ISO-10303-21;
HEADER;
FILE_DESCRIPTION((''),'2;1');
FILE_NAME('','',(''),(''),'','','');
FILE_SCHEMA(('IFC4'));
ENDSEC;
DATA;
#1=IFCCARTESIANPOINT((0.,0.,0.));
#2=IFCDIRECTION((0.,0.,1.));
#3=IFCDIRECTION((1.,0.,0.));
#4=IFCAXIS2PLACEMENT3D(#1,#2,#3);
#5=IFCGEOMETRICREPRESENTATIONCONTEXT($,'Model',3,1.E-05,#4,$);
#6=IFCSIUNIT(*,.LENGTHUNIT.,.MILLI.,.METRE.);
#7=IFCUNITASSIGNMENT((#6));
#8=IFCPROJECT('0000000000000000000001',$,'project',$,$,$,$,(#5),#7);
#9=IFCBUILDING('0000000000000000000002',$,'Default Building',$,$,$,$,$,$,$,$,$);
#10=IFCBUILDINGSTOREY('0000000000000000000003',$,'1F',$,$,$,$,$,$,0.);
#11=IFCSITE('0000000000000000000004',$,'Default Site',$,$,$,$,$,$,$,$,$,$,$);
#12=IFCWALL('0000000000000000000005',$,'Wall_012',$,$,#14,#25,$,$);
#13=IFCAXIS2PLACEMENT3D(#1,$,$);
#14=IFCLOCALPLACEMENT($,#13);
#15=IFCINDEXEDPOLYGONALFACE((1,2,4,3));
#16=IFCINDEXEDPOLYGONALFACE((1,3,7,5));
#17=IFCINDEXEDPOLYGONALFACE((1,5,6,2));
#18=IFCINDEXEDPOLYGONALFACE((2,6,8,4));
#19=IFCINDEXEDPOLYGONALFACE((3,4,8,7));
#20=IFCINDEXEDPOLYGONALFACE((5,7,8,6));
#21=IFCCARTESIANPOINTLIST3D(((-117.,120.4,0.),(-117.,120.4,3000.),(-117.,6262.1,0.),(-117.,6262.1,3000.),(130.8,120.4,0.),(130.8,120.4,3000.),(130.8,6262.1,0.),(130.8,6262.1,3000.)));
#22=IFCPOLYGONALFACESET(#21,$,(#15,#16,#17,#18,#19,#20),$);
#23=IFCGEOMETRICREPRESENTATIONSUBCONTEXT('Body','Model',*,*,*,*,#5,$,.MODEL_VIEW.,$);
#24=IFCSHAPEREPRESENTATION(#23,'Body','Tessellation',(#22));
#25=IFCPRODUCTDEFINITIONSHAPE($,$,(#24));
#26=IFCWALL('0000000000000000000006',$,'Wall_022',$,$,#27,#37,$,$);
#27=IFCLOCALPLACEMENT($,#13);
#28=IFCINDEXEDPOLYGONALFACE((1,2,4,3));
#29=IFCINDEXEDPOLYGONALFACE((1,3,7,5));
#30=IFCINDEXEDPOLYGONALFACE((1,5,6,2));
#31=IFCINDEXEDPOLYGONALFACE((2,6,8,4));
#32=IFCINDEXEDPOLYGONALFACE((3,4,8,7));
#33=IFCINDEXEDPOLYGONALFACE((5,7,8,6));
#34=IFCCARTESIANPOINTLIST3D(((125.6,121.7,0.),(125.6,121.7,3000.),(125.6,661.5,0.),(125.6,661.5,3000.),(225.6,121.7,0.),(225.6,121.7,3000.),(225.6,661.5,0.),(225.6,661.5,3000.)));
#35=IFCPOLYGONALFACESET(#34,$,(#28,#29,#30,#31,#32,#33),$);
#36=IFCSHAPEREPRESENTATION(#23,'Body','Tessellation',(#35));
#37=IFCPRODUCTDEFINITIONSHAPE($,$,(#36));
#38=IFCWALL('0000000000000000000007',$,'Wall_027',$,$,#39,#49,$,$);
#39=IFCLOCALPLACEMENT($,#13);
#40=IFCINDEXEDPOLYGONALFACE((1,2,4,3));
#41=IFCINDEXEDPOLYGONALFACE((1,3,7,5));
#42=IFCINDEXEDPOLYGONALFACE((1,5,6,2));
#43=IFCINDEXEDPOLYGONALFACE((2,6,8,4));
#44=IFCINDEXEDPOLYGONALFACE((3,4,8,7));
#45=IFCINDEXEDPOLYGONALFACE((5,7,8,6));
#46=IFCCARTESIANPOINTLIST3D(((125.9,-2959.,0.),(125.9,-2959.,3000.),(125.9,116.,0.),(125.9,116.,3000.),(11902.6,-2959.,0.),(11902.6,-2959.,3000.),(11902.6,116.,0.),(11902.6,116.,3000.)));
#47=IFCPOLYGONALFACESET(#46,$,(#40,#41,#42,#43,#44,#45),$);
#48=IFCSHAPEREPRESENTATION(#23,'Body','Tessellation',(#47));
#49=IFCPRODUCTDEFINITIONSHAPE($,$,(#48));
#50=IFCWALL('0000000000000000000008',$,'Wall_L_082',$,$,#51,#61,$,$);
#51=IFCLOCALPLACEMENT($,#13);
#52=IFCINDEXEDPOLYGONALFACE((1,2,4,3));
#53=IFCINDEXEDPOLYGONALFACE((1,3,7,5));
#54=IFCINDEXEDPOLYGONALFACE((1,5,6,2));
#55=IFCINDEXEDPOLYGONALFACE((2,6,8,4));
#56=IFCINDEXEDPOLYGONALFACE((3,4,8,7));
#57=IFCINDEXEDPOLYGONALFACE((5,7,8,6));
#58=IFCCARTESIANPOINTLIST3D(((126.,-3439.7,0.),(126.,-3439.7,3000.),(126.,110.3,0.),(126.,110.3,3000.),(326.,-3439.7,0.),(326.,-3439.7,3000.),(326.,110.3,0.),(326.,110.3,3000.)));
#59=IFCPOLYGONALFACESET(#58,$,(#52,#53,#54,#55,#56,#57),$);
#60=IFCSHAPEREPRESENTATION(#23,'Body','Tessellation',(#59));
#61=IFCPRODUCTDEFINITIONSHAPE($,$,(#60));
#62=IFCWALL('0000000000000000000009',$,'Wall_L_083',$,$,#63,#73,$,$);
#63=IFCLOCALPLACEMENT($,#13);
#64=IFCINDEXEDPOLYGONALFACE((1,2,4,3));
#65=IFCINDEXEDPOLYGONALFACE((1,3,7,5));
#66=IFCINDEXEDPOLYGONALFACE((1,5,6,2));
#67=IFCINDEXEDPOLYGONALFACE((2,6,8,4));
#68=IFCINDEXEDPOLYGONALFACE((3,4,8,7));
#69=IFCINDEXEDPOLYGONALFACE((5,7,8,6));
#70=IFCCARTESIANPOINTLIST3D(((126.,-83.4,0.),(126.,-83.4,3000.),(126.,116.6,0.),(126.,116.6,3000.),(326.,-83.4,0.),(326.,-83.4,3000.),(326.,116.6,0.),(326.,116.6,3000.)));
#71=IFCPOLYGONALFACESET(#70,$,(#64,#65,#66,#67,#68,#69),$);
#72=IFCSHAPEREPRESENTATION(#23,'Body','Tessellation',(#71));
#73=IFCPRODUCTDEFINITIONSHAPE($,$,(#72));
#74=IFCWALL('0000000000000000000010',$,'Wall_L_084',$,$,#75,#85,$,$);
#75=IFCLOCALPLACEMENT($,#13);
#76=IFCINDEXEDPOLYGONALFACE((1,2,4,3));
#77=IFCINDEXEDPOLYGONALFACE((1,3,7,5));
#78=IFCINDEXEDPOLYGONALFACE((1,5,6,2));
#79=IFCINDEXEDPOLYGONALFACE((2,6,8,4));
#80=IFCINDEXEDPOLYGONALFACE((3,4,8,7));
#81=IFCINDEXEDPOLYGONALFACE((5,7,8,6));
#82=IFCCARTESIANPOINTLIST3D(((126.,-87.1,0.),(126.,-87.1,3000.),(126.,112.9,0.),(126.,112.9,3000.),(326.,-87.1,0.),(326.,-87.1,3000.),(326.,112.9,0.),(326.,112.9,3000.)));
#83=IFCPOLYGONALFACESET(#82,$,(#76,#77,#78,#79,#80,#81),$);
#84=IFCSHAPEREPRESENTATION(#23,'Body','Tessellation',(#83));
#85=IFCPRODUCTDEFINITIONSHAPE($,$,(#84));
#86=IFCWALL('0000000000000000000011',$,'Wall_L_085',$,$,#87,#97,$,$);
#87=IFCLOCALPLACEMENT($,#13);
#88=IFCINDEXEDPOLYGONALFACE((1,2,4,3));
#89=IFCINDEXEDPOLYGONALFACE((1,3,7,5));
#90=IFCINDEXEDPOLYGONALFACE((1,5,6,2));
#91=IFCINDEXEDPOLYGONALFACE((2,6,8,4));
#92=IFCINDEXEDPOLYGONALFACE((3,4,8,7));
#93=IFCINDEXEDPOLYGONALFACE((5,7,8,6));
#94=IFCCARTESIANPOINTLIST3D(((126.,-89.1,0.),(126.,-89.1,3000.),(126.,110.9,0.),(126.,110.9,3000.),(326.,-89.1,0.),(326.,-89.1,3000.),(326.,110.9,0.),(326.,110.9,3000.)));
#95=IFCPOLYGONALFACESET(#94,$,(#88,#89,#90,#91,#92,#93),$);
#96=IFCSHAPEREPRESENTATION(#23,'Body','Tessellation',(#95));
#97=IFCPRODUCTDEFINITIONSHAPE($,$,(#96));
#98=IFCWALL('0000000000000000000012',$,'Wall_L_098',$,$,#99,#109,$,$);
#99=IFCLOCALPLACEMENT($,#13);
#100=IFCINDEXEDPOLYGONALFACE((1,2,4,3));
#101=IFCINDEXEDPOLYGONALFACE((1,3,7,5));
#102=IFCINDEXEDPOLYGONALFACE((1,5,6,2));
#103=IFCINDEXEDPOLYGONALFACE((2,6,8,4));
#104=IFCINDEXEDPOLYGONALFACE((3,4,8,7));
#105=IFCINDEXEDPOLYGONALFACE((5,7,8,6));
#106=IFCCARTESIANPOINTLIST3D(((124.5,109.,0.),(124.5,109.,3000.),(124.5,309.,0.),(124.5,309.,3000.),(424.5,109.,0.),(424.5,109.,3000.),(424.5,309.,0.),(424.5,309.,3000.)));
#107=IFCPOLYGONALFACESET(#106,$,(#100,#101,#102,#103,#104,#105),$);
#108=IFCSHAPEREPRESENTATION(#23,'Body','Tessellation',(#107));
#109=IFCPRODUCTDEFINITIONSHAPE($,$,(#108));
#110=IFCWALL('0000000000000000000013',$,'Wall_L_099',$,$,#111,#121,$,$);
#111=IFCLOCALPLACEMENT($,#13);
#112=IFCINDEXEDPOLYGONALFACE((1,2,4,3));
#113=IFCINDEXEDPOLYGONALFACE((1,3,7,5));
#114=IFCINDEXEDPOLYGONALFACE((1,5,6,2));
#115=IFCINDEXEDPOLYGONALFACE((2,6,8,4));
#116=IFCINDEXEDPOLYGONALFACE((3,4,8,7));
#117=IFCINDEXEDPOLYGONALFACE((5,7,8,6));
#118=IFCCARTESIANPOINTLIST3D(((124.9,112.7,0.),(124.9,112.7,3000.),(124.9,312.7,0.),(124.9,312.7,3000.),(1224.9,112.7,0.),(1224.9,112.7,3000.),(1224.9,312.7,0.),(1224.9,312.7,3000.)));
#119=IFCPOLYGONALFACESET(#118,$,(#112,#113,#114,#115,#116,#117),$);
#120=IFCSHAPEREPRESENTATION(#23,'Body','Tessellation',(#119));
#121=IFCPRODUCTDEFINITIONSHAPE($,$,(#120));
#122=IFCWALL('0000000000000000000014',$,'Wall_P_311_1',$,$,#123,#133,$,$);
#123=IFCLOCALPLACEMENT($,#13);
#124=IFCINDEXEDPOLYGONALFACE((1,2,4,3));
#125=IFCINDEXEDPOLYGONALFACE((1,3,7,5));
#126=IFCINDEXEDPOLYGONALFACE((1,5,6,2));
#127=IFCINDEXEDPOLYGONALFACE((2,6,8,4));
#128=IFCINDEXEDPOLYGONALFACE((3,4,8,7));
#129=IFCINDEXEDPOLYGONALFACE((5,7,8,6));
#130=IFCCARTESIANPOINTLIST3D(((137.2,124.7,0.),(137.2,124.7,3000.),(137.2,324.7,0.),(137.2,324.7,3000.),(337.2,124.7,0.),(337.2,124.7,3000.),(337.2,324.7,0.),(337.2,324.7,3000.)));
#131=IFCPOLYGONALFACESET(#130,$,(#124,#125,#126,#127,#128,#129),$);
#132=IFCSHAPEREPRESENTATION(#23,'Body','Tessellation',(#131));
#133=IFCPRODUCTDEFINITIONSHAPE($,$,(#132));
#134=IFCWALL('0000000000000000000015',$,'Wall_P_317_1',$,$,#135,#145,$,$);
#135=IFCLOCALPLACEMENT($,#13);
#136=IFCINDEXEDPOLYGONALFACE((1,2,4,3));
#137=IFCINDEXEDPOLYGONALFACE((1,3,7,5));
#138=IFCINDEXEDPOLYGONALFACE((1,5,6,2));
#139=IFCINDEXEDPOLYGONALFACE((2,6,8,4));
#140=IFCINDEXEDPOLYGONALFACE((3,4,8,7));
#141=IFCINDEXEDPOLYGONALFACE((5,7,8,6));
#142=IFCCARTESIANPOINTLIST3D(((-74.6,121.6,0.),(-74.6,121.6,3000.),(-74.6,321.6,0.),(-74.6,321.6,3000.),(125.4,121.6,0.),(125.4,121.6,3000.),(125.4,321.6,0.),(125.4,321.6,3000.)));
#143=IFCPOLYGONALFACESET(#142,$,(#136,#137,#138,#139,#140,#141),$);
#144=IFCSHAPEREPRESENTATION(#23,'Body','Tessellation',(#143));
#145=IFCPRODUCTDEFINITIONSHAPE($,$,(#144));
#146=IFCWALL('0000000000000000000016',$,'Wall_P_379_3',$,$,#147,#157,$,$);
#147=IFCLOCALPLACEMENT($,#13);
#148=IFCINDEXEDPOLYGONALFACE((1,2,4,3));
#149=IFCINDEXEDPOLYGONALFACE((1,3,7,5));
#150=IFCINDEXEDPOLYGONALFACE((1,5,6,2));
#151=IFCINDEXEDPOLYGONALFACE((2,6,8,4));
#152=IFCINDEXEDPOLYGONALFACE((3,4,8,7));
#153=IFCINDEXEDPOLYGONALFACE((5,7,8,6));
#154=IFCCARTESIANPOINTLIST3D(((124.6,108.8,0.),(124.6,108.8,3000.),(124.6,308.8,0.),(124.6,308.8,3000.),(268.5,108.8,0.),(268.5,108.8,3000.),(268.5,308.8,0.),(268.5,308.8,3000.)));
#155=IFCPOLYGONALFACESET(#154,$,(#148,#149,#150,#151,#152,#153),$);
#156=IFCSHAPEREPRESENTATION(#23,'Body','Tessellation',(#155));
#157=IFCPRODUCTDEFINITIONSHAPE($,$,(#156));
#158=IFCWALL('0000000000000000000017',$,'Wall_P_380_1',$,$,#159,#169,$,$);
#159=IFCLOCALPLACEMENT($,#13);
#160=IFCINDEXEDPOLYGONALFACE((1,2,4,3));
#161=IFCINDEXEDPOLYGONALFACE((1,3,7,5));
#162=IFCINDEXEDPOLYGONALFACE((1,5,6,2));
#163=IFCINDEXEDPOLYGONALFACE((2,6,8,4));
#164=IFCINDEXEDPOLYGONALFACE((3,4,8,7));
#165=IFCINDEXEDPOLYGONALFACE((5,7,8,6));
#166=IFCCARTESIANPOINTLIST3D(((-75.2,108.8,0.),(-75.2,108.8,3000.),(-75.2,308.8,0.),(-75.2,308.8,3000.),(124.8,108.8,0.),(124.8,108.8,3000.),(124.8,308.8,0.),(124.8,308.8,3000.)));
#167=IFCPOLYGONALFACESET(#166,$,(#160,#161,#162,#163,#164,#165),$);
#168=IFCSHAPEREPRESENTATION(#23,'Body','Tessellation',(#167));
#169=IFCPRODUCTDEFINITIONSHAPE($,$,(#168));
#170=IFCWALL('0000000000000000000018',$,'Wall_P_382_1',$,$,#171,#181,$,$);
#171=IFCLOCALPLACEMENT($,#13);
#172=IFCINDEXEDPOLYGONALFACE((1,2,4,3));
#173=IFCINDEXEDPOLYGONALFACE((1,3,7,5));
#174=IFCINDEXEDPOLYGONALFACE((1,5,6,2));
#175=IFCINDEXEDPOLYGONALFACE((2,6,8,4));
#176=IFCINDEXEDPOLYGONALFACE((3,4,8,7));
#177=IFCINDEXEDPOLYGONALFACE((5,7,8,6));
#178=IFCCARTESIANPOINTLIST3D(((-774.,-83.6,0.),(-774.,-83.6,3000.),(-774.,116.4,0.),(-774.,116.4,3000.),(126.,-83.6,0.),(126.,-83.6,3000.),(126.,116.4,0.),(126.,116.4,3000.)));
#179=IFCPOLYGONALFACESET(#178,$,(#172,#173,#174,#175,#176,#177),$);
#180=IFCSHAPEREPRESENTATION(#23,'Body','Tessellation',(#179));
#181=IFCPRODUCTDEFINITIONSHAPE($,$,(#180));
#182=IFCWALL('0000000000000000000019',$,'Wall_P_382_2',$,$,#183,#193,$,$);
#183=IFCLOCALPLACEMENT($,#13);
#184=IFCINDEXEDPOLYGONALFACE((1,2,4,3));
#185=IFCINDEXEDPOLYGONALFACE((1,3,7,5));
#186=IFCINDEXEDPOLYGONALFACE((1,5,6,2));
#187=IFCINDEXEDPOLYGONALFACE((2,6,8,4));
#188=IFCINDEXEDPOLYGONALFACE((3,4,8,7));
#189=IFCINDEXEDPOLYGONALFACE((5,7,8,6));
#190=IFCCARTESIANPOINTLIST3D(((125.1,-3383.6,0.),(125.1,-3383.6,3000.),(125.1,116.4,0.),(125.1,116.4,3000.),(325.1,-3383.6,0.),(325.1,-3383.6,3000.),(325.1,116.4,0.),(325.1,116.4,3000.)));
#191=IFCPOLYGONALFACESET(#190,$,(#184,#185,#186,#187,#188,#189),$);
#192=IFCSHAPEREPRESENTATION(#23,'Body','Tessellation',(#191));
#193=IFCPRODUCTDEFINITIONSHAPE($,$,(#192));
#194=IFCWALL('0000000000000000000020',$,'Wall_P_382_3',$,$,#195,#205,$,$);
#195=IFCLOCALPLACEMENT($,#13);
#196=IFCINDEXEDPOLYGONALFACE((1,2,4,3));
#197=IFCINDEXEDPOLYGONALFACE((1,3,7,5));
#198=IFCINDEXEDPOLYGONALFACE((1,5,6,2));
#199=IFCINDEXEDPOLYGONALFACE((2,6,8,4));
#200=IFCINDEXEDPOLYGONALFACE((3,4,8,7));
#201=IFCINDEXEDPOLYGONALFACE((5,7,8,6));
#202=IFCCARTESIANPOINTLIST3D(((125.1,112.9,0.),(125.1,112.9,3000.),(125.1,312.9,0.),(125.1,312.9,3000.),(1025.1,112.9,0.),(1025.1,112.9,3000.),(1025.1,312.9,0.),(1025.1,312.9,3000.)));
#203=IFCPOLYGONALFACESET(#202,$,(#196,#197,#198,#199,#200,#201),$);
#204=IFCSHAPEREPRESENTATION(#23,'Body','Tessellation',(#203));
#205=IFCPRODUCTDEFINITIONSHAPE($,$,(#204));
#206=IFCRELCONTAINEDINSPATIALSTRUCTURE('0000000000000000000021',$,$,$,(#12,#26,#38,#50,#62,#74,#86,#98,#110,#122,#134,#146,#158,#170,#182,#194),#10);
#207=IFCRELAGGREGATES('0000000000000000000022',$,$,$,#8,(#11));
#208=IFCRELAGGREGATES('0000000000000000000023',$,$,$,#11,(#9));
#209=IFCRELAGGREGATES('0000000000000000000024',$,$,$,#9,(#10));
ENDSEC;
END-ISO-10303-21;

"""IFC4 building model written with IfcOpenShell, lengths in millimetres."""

from ifc_helpers import new_model, si_unit, frame, origin_with_axes, place, context, subcontext, project, spatial, indexed_curve, outline, extrude, element, save


model = new_model("IFC4")

# Units and contexts
model_context = context("Model", 3, precision=1e-05, world=origin_with_axes())
body_context = subcontext(model_context, "Body", "Model", "MODEL_VIEW")
ifc_project = project(units=[si_unit("LENGTHUNIT", "METRE", prefix="MILLI")], contexts=[model_context])

# Site, building, storey
site = spatial("IfcSite", under=ifc_project, Name="Default Site")
building = spatial("IfcBuilding", under=site, Name="Default Building")
storey = spatial("IfcBuildingStorey", under=building, Name="1F", Elevation=0.0)

# Walls
wall_1_placement = place(None, frame((130.8, 120.4, 0.0), z_axis=(0.0, 0.0, 1.0), x_axis=(0.0, 1.0, 0.0)))
element("IfcWall", 1, at=wall_1_placement, inside=storey, Name="Wall_012", context=body_context, shape_type="SweptSolid", body=[
    extrude(outline(indexed_curve([(0.0, 0.0), (0.0, 247.8), (6141.6, 247.8), (6141.6, 0.0), (0.0, 0.0)], self_intersect=False)), origin_with_axes(), (0.0, 0.0, 1.0), 3000.0),
])
wall_2_placement = place(None, frame((125.6, 121.7, 0.0), z_axis=(0.0, 0.0, 1.0), x_axis=(1.0, 0.0, 0.0)))
element("IfcWall", 2, at=wall_2_placement, inside=storey, Name="Wall_022", context=body_context, shape_type="SweptSolid", body=[
    extrude(outline(indexed_curve([(0.0, 0.0), (0.0, 539.8), (100.0, 539.8), (100.0, 0.0), (0.0, 0.0)], self_intersect=False)), origin_with_axes(), (0.0, 0.0, 1.0), 3000.0),
])
wall_3_placement = place(None, frame((125.9, 116.0, 0.0), z_axis=(0.0, 0.0, 1.0), x_axis=(0.0, -1.0, 0.0)))
element("IfcWall", 3, at=wall_3_placement, inside=storey, Name="Wall_027", context=body_context, shape_type="SweptSolid", body=[
    extrude(outline(indexed_curve([(0.0, 0.0), (0.0, 11776.7), (3075.0, 11776.7), (3075.0, 0.0), (0.0, 0.0)], self_intersect=False)), origin_with_axes(), (0.0, 0.0, 1.0), 3000.0),
])
wall_4_placement = place(None, frame((126.0, 110.3, 0.0), z_axis=(0.0, 0.0, 1.0), x_axis=(0.0, -1.0, 0.0)))
element("IfcWall", 4, at=wall_4_placement, inside=storey, Name="Wall_L_082", context=body_context, shape_type="SweptSolid", body=[
    extrude(outline(indexed_curve([(0.0, 0.0), (0.0, 200.0), (3550.0, 200.0), (3550.0, 0.0), (0.0, 0.0)], self_intersect=False)), origin_with_axes(), (0.0, 0.0, 1.0), 3000.0),
])
wall_5_placement = place(None, frame((126.0, 116.6, 0.0), z_axis=(0.0, 0.0, 1.0), x_axis=(0.0, -1.0, 0.0)))
element("IfcWall", 5, at=wall_5_placement, inside=storey, Name="Wall_L_083", context=body_context, shape_type="SweptSolid", body=[
    extrude(outline(indexed_curve([(0.0, 0.0), (0.0, 200.0), (200.0, 200.0), (200.0, 0.0), (0.0, 0.0)], self_intersect=False)), origin_with_axes(), (0.0, 0.0, 1.0), 3000.0),
])
for number, where, z_axis, x_axis, name in (
    (6, (126.0, 112.9, 0.0), (0.0, 0.0, 1.0), (0.0, -1.0, 0.0), "Wall_L_084"),
    (7, (126.0, 110.9, 0.0), (0.0, 0.0, 1.0), (0.0, -1.0, 0.0), "Wall_L_085"),
):
    element("IfcWall", number, at=place(None, frame(where, z_axis=z_axis, x_axis=x_axis)), inside=storey, Name=name, context=body_context, shape_type="SweptSolid", body=[
        extrude(outline(indexed_curve([(0.0, 0.0), (0.0, 200.0), (200.0, 200.0), (200.0, 0.0), (0.0, 0.0)], self_intersect=False)), origin_with_axes(), (0.0, 0.0, 1.0), 3000.0),
    ])
wall_6_placement = place(None, frame((124.5, 109.0, 0.0), z_axis=(0.0, 0.0, 1.0), x_axis=(1.0, 0.0, 0.0)))
element("IfcWall", 8, at=wall_6_placement, inside=storey, Name="Wall_L_098", context=body_context, shape_type="SweptSolid", body=[
    extrude(outline(indexed_curve([(0.0, 0.0), (0.0, 200.0), (300.0, 200.0), (300.0, 0.0), (0.0, 0.0)], self_intersect=False)), origin_with_axes(), (0.0, 0.0, 1.0), 3000.0),
])
wall_7_placement = place(None, frame((124.9, 112.7, 0.0), z_axis=(0.0, 0.0, 1.0), x_axis=(1.0, 0.0, 0.0)))
element("IfcWall", 9, at=wall_7_placement, inside=storey, Name="Wall_L_099", context=body_context, shape_type="SweptSolid", body=[
    extrude(outline(indexed_curve([(0.0, 0.0), (0.0, 200.0), (1100.0, 200.0), (1100.0, 0.0), (0.0, 0.0)], self_intersect=False)), origin_with_axes(), (0.0, 0.0, 1.0), 3000.0),
])
wall_8_placement = place(None, frame((137.2, 124.7, 0.0), z_axis=(0.0, 0.0, 1.0), x_axis=(1.0, 0.0, 0.0)))
element("IfcWall", 10, at=wall_8_placement, inside=storey, Name="Wall_P_311_1", context=body_context, shape_type="SweptSolid", body=[
    extrude(outline(indexed_curve([(0.0, 0.0), (0.0, 200.0), (200.0, 200.0), (200.0, 0.0), (0.0, 0.0)], self_intersect=False)), origin_with_axes(), (0.0, 0.0, 1.0), 3000.0),
])
wall_9_placement = place(None, frame((125.4, 121.6, 0.0), z_axis=(0.0, 0.0, 1.0), x_axis=(0.0, 1.0, 0.0)))
element("IfcWall", 11, at=wall_9_placement, inside=storey, Name="Wall_P_317_1", context=body_context, shape_type="SweptSolid", body=[
    extrude(outline(indexed_curve([(0.0, 0.0), (0.0, 200.0), (200.0, 200.0), (200.0, 0.0), (0.0, 0.0)], self_intersect=False)), origin_with_axes(), (0.0, 0.0, 1.0), 3000.0),
])
wall_10_placement = place(None, frame((124.6, 108.8, 0.0), z_axis=(0.0, 0.0, 1.0), x_axis=(1.0, 0.0, 0.0)))
element("IfcWall", 12, at=wall_10_placement, inside=storey, Name="Wall_P_379_3", context=body_context, shape_type="SweptSolid", body=[
    extrude(outline(indexed_curve([(0.0, 0.0), (0.0, 200.0), (143.8, 200.0), (143.8, 0.0), (0.0, 0.0)], self_intersect=False)), origin_with_axes(), (0.0, 0.0, 1.0), 3000.0),
])
wall_11_placement = place(None, frame((124.8, 108.8, 0.0), z_axis=(0.0, 0.0, 1.0), x_axis=(0.0, 1.0, 0.0)))
element("IfcWall", 13, at=wall_11_placement, inside=storey, Name="Wall_P_380_1", context=body_context, shape_type="SweptSolid", body=[
    extrude(outline(indexed_curve([(0.0, 0.0), (0.0, 200.0), (200.0, 200.0), (200.0, 0.0), (0.0, 0.0)], self_intersect=False)), origin_with_axes(), (0.0, 0.0, 1.0), 3000.0),
])
wall_12_placement = place(None, frame((126.0, 116.4, 0.0), z_axis=(0.0, 0.0, 1.0), x_axis=(-1.0, 0.0, 0.0)))
element("IfcWall", 14, at=wall_12_placement, inside=storey, Name="Wall_P_382_1", context=body_context, shape_type="SweptSolid", body=[
    extrude(outline(indexed_curve([(0.0, 0.0), (0.0, 200.0), (900.0, 200.0), (900.0, 0.0), (0.0, 0.0)], self_intersect=False)), origin_with_axes(), (0.0, 0.0, 1.0), 3000.0),
])
wall_13_placement = place(None, frame((125.1, 116.4, 0.0), z_axis=(0.0, 0.0, 1.0), x_axis=(0.0, -1.0, 0.0)))
element("IfcWall", 15, at=wall_13_placement, inside=storey, Name="Wall_P_382_2", context=body_context, shape_type="SweptSolid", body=[
    extrude(outline(indexed_curve([(0.0, 0.0), (0.0, 200.0), (3500.0, 200.0), (3500.0, 0.0), (0.0, 0.0)], self_intersect=False)), origin_with_axes(), (0.0, 0.0, 1.0), 3000.0),
])
wall_14_placement = place(None, frame((125.1, 112.9, 0.0), z_axis=(0.0, 0.0, 1.0), x_axis=(1.0, 0.0, 0.0)))
element("IfcWall", 16, at=wall_14_placement, inside=storey, Name="Wall_P_382_3", context=body_context, shape_type="SweptSolid", body=[
    extrude(outline(indexed_curve([(0.0, 0.0), (0.0, 200.0), (900.0, 200.0), (900.0, 0.0), (0.0, 0.0)], self_intersect=False)), origin_with_axes(), (0.0, 0.0, 1.0), 3000.0),
])

save(model, "model.ifc")
